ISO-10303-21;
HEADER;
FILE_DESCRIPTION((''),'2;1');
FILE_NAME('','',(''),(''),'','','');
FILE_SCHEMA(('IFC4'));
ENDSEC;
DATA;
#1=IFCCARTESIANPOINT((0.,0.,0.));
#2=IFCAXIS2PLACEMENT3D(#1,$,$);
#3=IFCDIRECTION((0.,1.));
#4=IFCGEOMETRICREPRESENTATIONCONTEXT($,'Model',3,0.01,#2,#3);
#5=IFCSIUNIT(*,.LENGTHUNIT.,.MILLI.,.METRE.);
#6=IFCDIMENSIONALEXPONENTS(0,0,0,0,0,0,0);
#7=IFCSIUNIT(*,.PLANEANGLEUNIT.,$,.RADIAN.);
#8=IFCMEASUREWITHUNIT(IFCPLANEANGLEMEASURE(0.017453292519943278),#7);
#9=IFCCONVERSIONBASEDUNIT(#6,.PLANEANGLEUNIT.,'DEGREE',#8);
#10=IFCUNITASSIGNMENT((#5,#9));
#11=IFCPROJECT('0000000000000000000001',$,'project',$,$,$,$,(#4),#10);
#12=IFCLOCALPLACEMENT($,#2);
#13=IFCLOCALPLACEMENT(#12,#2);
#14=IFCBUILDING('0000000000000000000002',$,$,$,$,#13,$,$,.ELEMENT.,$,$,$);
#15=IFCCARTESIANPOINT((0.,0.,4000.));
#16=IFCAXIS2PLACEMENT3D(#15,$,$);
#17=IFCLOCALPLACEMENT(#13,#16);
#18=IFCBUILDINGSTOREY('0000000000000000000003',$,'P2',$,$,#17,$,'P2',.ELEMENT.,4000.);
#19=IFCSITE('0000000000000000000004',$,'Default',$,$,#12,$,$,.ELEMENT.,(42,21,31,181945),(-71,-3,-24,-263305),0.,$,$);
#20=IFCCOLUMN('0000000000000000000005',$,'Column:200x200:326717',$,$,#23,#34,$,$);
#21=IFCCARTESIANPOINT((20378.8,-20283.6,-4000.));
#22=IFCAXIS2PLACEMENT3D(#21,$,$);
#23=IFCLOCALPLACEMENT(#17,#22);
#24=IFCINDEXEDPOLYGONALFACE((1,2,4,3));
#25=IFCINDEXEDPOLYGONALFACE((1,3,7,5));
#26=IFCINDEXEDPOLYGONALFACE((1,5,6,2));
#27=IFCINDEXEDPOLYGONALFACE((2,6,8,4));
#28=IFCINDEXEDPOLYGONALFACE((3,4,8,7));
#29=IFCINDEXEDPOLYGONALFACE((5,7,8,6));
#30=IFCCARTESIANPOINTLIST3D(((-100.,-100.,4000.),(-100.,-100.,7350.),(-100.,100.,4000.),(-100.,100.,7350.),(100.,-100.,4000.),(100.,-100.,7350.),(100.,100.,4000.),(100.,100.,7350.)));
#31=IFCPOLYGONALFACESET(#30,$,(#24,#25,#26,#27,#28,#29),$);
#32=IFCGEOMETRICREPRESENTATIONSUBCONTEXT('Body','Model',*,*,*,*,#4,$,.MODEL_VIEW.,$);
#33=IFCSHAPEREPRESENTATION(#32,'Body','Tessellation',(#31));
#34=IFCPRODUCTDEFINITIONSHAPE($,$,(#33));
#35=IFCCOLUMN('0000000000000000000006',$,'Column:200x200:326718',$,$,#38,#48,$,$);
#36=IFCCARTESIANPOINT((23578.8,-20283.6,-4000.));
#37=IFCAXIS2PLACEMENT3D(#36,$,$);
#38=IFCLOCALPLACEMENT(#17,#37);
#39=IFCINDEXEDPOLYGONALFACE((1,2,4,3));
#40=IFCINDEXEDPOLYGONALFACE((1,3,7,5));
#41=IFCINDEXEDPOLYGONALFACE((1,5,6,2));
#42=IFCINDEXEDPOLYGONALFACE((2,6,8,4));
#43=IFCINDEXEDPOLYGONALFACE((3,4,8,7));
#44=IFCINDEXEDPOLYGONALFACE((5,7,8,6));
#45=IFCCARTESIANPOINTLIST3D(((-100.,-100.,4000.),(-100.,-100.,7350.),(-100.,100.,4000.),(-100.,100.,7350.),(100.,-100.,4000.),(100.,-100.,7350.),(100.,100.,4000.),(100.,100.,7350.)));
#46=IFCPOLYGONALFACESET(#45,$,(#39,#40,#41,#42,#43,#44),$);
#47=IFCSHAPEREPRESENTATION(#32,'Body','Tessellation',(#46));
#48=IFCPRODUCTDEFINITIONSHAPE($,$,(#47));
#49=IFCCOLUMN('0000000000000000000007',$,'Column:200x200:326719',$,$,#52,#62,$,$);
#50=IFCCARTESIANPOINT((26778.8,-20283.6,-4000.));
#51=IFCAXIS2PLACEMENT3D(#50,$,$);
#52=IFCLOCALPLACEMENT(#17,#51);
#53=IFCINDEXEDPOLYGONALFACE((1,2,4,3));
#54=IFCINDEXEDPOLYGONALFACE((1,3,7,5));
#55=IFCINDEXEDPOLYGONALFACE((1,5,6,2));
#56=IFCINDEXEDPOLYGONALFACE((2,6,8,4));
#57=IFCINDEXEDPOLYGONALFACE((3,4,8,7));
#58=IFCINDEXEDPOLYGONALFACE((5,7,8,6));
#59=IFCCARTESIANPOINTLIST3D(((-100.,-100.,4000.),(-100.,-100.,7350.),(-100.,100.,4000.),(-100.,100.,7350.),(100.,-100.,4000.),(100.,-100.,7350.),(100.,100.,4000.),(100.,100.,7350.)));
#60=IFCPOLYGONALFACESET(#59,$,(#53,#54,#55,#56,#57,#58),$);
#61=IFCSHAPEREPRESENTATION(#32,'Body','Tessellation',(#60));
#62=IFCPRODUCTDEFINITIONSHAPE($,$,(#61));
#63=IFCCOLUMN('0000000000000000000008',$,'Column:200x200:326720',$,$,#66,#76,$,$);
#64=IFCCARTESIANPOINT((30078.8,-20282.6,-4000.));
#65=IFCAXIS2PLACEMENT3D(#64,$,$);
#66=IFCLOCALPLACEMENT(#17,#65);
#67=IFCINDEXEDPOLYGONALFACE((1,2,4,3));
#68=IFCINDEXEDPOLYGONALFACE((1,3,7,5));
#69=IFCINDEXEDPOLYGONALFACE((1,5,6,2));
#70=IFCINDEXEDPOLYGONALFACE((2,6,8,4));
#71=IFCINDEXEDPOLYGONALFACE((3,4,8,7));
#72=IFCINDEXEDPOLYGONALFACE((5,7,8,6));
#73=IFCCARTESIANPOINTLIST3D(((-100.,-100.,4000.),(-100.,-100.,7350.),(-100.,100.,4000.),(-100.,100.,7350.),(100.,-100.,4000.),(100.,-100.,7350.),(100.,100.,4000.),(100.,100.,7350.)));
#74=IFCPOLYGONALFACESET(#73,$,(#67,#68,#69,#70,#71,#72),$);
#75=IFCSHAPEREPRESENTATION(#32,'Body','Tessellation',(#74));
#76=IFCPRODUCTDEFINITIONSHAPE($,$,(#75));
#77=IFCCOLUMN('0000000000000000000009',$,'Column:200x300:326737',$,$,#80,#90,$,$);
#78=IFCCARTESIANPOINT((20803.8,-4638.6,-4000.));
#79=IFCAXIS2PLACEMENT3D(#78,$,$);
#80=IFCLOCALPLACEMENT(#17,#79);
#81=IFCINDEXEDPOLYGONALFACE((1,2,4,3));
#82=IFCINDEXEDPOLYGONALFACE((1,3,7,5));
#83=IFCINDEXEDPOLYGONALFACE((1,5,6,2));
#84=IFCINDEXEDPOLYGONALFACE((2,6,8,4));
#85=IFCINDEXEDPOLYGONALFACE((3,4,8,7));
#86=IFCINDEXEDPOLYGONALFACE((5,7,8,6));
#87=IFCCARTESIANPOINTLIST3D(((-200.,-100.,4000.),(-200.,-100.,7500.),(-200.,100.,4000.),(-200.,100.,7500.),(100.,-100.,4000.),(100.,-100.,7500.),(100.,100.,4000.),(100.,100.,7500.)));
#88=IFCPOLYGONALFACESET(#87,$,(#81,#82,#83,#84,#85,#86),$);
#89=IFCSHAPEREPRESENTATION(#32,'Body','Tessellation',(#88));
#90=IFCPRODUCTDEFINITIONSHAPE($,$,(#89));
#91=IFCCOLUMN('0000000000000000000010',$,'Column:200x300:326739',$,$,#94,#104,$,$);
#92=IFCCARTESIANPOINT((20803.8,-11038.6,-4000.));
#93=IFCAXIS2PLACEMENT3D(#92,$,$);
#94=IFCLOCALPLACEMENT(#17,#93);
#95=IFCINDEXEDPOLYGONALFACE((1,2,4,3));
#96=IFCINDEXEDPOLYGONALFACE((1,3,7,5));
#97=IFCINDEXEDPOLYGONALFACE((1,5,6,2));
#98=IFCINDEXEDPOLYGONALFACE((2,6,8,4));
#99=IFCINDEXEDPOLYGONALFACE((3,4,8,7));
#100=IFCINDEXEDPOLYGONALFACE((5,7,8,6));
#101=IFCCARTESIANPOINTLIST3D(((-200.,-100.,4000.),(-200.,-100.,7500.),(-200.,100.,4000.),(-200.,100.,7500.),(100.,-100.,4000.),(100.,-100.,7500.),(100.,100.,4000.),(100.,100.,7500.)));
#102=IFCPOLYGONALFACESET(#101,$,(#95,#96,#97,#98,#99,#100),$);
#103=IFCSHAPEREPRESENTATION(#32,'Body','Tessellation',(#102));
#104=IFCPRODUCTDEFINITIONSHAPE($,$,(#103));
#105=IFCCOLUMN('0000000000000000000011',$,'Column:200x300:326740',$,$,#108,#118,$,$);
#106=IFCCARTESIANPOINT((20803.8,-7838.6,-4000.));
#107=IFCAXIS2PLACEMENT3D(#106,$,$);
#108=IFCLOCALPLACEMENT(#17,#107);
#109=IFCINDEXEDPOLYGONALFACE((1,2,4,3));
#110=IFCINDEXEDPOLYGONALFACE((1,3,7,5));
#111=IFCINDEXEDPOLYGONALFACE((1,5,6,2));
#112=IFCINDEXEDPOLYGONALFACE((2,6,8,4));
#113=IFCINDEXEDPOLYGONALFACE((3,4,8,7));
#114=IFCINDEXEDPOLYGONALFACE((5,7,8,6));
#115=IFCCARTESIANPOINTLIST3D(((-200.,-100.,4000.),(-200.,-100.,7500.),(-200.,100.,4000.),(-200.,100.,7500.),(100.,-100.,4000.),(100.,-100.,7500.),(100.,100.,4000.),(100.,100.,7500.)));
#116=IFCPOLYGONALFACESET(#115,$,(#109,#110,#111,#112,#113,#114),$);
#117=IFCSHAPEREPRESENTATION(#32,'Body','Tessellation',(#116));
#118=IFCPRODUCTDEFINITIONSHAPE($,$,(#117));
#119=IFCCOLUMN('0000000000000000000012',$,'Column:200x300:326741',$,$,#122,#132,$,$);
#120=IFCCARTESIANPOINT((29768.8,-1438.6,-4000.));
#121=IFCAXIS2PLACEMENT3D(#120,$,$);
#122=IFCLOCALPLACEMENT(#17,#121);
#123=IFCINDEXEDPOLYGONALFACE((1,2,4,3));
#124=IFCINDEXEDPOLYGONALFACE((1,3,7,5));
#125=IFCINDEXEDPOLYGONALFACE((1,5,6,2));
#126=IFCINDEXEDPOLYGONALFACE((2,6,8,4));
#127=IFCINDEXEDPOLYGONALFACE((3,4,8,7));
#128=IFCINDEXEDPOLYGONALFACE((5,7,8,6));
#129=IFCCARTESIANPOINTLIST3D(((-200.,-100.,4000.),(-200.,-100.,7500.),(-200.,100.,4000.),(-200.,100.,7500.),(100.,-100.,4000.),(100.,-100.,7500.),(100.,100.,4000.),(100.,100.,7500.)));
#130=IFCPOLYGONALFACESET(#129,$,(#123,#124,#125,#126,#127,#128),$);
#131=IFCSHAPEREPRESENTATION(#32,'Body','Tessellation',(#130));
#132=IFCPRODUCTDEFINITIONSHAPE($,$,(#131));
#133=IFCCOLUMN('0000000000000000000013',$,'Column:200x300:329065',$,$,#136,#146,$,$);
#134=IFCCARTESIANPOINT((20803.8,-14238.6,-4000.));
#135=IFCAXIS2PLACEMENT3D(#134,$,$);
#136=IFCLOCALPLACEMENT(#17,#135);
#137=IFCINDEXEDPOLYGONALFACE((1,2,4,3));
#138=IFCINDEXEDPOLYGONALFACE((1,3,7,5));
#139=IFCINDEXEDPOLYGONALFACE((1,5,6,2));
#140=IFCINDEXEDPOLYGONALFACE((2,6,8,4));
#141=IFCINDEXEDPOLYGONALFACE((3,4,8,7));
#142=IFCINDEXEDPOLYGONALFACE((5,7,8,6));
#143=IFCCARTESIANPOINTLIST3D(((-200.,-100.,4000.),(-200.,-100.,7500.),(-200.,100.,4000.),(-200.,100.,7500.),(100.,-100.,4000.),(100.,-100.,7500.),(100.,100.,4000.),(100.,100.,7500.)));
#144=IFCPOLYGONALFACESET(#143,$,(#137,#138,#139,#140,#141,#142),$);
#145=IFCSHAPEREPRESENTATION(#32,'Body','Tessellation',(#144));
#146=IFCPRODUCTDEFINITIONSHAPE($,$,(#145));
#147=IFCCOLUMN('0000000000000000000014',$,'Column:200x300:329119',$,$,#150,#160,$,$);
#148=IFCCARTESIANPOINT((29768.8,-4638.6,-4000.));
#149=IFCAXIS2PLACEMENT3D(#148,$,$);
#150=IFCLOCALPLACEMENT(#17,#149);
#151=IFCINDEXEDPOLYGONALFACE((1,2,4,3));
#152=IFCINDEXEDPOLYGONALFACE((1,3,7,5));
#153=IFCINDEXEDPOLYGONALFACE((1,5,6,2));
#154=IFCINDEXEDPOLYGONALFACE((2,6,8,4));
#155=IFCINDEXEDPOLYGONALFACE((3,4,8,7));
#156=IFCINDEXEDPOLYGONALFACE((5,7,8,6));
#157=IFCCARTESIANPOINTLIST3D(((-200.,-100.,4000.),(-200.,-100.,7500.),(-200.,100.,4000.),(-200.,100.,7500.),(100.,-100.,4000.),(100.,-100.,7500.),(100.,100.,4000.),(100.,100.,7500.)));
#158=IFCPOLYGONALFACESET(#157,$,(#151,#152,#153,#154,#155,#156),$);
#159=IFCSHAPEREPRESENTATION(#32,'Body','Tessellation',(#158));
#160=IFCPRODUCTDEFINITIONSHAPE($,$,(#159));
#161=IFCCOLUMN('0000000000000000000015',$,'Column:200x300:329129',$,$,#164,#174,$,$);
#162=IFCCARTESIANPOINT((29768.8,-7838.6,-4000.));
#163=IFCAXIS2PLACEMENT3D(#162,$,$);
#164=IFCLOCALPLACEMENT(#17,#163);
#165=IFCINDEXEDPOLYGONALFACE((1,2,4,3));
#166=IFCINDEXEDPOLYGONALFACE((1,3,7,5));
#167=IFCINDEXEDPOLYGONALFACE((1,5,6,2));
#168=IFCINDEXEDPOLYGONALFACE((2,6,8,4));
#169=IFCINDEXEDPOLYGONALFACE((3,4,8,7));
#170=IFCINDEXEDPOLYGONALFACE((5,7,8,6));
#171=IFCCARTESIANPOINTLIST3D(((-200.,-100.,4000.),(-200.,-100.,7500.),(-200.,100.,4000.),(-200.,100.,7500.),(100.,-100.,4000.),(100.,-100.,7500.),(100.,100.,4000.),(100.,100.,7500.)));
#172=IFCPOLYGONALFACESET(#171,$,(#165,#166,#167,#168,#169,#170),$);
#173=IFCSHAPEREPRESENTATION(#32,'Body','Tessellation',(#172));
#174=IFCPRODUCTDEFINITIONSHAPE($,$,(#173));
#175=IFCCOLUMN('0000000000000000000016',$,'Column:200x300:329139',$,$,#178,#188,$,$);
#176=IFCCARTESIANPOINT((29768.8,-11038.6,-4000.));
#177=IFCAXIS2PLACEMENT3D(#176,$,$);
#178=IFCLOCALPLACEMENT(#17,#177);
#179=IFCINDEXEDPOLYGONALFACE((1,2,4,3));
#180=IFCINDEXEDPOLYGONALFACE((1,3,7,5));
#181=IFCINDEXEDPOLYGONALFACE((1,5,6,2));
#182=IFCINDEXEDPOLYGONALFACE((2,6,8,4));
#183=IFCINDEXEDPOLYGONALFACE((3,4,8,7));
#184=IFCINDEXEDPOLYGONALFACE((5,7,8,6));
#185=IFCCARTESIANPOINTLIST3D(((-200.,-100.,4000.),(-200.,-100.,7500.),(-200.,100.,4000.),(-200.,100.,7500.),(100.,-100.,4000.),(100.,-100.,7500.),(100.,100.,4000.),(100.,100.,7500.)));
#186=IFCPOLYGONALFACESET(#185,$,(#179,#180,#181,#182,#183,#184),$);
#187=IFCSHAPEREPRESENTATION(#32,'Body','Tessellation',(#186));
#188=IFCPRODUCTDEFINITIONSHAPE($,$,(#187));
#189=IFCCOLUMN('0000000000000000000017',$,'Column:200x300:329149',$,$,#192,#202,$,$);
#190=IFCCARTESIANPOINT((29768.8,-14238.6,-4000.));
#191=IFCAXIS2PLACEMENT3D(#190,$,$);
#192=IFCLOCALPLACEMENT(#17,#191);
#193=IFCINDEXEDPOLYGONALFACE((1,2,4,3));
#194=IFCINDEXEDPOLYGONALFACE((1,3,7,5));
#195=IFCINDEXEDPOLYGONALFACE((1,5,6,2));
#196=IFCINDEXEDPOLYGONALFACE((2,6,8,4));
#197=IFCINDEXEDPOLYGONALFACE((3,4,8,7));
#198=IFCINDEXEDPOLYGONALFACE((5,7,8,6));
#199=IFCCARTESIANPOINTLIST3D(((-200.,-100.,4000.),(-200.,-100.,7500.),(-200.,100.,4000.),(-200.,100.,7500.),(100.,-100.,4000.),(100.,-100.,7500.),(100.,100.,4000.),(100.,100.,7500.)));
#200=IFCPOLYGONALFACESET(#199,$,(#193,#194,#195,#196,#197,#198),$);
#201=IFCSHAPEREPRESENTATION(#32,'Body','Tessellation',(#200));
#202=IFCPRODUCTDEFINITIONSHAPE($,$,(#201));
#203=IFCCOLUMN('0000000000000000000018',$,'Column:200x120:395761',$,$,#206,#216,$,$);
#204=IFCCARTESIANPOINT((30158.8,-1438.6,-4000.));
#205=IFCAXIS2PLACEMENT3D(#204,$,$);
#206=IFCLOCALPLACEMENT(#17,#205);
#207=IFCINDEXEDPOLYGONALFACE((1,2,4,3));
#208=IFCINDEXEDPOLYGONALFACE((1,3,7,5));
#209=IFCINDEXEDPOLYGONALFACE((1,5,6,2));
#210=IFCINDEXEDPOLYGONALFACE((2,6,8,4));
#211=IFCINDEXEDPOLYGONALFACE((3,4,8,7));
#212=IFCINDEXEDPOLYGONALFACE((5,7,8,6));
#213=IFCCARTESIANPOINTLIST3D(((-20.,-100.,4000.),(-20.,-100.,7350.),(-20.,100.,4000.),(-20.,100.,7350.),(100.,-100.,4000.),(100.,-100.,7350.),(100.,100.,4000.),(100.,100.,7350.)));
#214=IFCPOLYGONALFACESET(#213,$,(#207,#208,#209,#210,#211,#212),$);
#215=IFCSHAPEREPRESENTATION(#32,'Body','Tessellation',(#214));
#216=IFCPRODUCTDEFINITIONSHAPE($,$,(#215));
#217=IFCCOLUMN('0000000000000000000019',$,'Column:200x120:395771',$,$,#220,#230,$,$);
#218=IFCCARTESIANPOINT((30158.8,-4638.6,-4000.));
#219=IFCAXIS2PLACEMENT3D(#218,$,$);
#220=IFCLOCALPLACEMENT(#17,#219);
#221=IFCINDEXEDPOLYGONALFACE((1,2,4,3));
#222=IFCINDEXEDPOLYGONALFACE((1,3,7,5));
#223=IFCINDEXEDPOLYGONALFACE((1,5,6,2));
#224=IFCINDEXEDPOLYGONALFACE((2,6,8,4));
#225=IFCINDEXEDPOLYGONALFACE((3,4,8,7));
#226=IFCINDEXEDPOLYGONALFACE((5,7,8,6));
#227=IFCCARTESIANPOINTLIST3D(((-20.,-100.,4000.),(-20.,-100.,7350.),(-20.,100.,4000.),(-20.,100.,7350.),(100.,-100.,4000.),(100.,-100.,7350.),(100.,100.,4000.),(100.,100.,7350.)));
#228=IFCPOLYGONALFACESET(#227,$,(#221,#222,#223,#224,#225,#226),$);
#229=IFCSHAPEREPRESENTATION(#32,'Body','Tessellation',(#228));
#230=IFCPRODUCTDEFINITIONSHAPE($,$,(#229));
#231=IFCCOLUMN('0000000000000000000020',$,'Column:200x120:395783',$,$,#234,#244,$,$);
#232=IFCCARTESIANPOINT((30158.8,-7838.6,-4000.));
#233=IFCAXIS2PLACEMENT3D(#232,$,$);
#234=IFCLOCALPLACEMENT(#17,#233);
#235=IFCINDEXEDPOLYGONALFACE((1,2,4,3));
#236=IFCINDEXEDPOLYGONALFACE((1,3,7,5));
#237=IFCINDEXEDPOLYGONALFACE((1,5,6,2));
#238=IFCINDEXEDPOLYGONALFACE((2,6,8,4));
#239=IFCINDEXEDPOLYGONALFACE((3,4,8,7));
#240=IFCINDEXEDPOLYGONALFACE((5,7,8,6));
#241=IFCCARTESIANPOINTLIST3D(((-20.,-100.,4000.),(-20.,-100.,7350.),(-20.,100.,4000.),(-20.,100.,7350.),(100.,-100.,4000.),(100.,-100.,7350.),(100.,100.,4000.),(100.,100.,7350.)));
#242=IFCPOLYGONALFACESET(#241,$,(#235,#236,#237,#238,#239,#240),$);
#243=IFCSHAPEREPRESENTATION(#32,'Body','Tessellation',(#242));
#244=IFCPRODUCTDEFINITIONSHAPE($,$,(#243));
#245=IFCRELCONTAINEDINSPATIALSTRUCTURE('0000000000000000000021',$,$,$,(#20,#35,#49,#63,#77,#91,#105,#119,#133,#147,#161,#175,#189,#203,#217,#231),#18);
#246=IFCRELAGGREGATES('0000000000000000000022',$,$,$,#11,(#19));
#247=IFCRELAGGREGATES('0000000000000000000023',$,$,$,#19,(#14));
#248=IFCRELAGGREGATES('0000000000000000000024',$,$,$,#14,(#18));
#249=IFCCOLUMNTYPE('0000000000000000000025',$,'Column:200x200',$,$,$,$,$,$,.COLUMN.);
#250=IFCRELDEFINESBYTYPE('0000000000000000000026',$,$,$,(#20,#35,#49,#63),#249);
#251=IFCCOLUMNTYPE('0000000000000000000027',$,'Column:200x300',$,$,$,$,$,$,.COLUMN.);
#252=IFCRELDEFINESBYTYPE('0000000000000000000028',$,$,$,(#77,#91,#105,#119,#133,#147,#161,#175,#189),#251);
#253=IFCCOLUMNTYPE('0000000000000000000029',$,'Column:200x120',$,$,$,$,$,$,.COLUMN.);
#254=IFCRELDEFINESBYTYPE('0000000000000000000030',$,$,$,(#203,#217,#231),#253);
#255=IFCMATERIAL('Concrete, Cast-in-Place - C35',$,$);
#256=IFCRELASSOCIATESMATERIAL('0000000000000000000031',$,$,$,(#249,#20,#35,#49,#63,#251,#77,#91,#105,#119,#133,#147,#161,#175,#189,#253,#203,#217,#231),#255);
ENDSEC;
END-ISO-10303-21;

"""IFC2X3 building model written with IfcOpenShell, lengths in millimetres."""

from ifc_helpers import new_model, entity, si_unit, converted_unit, direction, frame, frame_2d, origin, origin_2d_with_axis, place, context, subcontext, project, spatial, rectangle, extrude, source, transform, mapped, material, type_object, type_shapes, element, save


model = new_model("IFC2X3")

# Units and contexts
model_context = context("Model", 3, precision=0.01, world=origin(), true_north=direction((0.0, 1.0)))
body_context = subcontext(model_context, "Body", "Model", "MODEL_VIEW")
ifc_project = project(units=[si_unit("LENGTHUNIT", "METRE", prefix="MILLI"), converted_unit("PLANEANGLEUNIT", "DEGREE", entity("IfcPlaneAngleMeasure", 0.017453292519943278), si_unit("PLANEANGLEUNIT", "RADIAN"), dimensions=[0, 0, 0, 0, 0, 0, 0])], contexts=[model_context])

# Site, building, storey
site_placement = place(None, origin())
site = spatial("IfcSite", under=ifc_project, at=site_placement, Name="Default", CompositionType="ELEMENT", RefLatitude=(42, 21, 31, 181945), RefLongitude=(-71, -3, -24, -263305), RefElevation=0.0)
building_placement = place(site_placement, origin())
building = spatial("IfcBuilding", under=site, at=building_placement, CompositionType="ELEMENT")
storey_placement = place(building_placement, frame((0.0, 0.0, 4000.0)))
storey = spatial("IfcBuildingStorey", under=building, at=storey_placement, Name="P2", LongName="P2", CompositionType="ELEMENT", Elevation=4000.0)

# Columns
ifc_material = material(Name="Concrete, Cast-in-Place - C35")
column_type_1 = type_object("IfcColumnType", Name="Column:200x200", PredefinedType="COLUMN", material=ifc_material)
shared_shape_1 = source(origin(), body_context, "Body", "SweptSolid", [
    extrude(rectangle(XDim=200.0, YDim=200.0, at=frame_2d((0.0, 0.0), x_axis=(1.0, 0.0))), frame((0.0, 0.0, 4000.0), z_axis=(0.0, 0.0, 1.0), x_axis=(-1.0, 0.0, 0.0)), (0.0, 0.0, 1.0), 3350.0),
])
type_shapes(column_type_1, [shared_shape_1])
for number, where, name in (
    (1, (20378.8, -20283.6, -4000.0), "Column:200x200:326717"),
    (2, (23578.8, -20283.6, -4000.0), "Column:200x200:326718"),
    (3, (26778.8, -20283.6, -4000.0), "Column:200x200:326719"),
    (4, (30078.8, -20282.6, -4000.0), "Column:200x200:326720"),
):
    element("IfcColumn", number, at=place(storey_placement, frame(where)), inside=storey, type_object=column_type_1, material=ifc_material, Name=name, context=body_context, shape_type="MappedRepresentation", body=[
        mapped(shared_shape_1, transform((0.0, 0.0, 0.0), scale=1.0)),
    ])
column_type_2 = type_object("IfcColumnType", Name="Column:200x300", PredefinedType="COLUMN", material=ifc_material)
shared_shape_2 = source(origin(), body_context, "Body", "SweptSolid", [
    extrude(rectangle(XDim=300.0, YDim=200.0, at=origin_2d_with_axis()), frame((-50.0, 0.0, 4000.0), z_axis=(0.0, 0.0, 1.0), x_axis=(-1.0, 0.0, 0.0)), (0.0, 0.0, 1.0), 3500.0),
])
type_shapes(column_type_2, [shared_shape_2])
for number, where, name in (
    (5, (20803.8, -4638.6, -4000.0), "Column:200x300:326737"),
    (6, (20803.8, -11038.6, -4000.0), "Column:200x300:326739"),
    (7, (20803.8, -7838.6, -4000.0), "Column:200x300:326740"),
    (8, (29768.8, -1438.6, -4000.0), "Column:200x300:326741"),
    (9, (20803.8, -14238.6, -4000.0), "Column:200x300:329065"),
    (10, (29768.8, -4638.6, -4000.0), "Column:200x300:329119"),
    (11, (29768.8, -7838.6, -4000.0), "Column:200x300:329129"),
    (12, (29768.8, -11038.6, -4000.0), "Column:200x300:329139"),
    (13, (29768.8, -14238.6, -4000.0), "Column:200x300:329149"),
):
    element("IfcColumn", number, at=place(storey_placement, frame(where)), inside=storey, type_object=column_type_2, material=ifc_material, Name=name, context=body_context, shape_type="MappedRepresentation", body=[
        mapped(shared_shape_2, transform((0.0, 0.0, 0.0), scale=1.0)),
    ])
column_type_3 = type_object("IfcColumnType", Name="Column:200x120", PredefinedType="COLUMN", material=ifc_material)
shared_shape_3 = source(origin(), body_context, "Body", "SweptSolid", [
    extrude(rectangle(XDim=120.0, YDim=200.0, at=origin_2d_with_axis()), frame((40.0, 0.0, 4000.0), z_axis=(0.0, 0.0, 1.0), x_axis=(-1.0, 0.0, 0.0)), (0.0, 0.0, 1.0), 3350.0),
])
type_shapes(column_type_3, [shared_shape_3])
for number, where, name in (
    (14, (30158.8, -1438.6, -4000.0), "Column:200x120:395761"),
    (15, (30158.8, -4638.6, -4000.0), "Column:200x120:395771"),
    (16, (30158.8, -7838.6, -4000.0), "Column:200x120:395783"),
):
    element("IfcColumn", number, at=place(storey_placement, frame(where)), inside=storey, type_object=column_type_3, material=ifc_material, Name=name, context=body_context, shape_type="MappedRepresentation", body=[
        mapped(shared_shape_3, transform((0.0, 0.0, 0.0), scale=1.0)),
    ])

save(model, "model.ifc")
